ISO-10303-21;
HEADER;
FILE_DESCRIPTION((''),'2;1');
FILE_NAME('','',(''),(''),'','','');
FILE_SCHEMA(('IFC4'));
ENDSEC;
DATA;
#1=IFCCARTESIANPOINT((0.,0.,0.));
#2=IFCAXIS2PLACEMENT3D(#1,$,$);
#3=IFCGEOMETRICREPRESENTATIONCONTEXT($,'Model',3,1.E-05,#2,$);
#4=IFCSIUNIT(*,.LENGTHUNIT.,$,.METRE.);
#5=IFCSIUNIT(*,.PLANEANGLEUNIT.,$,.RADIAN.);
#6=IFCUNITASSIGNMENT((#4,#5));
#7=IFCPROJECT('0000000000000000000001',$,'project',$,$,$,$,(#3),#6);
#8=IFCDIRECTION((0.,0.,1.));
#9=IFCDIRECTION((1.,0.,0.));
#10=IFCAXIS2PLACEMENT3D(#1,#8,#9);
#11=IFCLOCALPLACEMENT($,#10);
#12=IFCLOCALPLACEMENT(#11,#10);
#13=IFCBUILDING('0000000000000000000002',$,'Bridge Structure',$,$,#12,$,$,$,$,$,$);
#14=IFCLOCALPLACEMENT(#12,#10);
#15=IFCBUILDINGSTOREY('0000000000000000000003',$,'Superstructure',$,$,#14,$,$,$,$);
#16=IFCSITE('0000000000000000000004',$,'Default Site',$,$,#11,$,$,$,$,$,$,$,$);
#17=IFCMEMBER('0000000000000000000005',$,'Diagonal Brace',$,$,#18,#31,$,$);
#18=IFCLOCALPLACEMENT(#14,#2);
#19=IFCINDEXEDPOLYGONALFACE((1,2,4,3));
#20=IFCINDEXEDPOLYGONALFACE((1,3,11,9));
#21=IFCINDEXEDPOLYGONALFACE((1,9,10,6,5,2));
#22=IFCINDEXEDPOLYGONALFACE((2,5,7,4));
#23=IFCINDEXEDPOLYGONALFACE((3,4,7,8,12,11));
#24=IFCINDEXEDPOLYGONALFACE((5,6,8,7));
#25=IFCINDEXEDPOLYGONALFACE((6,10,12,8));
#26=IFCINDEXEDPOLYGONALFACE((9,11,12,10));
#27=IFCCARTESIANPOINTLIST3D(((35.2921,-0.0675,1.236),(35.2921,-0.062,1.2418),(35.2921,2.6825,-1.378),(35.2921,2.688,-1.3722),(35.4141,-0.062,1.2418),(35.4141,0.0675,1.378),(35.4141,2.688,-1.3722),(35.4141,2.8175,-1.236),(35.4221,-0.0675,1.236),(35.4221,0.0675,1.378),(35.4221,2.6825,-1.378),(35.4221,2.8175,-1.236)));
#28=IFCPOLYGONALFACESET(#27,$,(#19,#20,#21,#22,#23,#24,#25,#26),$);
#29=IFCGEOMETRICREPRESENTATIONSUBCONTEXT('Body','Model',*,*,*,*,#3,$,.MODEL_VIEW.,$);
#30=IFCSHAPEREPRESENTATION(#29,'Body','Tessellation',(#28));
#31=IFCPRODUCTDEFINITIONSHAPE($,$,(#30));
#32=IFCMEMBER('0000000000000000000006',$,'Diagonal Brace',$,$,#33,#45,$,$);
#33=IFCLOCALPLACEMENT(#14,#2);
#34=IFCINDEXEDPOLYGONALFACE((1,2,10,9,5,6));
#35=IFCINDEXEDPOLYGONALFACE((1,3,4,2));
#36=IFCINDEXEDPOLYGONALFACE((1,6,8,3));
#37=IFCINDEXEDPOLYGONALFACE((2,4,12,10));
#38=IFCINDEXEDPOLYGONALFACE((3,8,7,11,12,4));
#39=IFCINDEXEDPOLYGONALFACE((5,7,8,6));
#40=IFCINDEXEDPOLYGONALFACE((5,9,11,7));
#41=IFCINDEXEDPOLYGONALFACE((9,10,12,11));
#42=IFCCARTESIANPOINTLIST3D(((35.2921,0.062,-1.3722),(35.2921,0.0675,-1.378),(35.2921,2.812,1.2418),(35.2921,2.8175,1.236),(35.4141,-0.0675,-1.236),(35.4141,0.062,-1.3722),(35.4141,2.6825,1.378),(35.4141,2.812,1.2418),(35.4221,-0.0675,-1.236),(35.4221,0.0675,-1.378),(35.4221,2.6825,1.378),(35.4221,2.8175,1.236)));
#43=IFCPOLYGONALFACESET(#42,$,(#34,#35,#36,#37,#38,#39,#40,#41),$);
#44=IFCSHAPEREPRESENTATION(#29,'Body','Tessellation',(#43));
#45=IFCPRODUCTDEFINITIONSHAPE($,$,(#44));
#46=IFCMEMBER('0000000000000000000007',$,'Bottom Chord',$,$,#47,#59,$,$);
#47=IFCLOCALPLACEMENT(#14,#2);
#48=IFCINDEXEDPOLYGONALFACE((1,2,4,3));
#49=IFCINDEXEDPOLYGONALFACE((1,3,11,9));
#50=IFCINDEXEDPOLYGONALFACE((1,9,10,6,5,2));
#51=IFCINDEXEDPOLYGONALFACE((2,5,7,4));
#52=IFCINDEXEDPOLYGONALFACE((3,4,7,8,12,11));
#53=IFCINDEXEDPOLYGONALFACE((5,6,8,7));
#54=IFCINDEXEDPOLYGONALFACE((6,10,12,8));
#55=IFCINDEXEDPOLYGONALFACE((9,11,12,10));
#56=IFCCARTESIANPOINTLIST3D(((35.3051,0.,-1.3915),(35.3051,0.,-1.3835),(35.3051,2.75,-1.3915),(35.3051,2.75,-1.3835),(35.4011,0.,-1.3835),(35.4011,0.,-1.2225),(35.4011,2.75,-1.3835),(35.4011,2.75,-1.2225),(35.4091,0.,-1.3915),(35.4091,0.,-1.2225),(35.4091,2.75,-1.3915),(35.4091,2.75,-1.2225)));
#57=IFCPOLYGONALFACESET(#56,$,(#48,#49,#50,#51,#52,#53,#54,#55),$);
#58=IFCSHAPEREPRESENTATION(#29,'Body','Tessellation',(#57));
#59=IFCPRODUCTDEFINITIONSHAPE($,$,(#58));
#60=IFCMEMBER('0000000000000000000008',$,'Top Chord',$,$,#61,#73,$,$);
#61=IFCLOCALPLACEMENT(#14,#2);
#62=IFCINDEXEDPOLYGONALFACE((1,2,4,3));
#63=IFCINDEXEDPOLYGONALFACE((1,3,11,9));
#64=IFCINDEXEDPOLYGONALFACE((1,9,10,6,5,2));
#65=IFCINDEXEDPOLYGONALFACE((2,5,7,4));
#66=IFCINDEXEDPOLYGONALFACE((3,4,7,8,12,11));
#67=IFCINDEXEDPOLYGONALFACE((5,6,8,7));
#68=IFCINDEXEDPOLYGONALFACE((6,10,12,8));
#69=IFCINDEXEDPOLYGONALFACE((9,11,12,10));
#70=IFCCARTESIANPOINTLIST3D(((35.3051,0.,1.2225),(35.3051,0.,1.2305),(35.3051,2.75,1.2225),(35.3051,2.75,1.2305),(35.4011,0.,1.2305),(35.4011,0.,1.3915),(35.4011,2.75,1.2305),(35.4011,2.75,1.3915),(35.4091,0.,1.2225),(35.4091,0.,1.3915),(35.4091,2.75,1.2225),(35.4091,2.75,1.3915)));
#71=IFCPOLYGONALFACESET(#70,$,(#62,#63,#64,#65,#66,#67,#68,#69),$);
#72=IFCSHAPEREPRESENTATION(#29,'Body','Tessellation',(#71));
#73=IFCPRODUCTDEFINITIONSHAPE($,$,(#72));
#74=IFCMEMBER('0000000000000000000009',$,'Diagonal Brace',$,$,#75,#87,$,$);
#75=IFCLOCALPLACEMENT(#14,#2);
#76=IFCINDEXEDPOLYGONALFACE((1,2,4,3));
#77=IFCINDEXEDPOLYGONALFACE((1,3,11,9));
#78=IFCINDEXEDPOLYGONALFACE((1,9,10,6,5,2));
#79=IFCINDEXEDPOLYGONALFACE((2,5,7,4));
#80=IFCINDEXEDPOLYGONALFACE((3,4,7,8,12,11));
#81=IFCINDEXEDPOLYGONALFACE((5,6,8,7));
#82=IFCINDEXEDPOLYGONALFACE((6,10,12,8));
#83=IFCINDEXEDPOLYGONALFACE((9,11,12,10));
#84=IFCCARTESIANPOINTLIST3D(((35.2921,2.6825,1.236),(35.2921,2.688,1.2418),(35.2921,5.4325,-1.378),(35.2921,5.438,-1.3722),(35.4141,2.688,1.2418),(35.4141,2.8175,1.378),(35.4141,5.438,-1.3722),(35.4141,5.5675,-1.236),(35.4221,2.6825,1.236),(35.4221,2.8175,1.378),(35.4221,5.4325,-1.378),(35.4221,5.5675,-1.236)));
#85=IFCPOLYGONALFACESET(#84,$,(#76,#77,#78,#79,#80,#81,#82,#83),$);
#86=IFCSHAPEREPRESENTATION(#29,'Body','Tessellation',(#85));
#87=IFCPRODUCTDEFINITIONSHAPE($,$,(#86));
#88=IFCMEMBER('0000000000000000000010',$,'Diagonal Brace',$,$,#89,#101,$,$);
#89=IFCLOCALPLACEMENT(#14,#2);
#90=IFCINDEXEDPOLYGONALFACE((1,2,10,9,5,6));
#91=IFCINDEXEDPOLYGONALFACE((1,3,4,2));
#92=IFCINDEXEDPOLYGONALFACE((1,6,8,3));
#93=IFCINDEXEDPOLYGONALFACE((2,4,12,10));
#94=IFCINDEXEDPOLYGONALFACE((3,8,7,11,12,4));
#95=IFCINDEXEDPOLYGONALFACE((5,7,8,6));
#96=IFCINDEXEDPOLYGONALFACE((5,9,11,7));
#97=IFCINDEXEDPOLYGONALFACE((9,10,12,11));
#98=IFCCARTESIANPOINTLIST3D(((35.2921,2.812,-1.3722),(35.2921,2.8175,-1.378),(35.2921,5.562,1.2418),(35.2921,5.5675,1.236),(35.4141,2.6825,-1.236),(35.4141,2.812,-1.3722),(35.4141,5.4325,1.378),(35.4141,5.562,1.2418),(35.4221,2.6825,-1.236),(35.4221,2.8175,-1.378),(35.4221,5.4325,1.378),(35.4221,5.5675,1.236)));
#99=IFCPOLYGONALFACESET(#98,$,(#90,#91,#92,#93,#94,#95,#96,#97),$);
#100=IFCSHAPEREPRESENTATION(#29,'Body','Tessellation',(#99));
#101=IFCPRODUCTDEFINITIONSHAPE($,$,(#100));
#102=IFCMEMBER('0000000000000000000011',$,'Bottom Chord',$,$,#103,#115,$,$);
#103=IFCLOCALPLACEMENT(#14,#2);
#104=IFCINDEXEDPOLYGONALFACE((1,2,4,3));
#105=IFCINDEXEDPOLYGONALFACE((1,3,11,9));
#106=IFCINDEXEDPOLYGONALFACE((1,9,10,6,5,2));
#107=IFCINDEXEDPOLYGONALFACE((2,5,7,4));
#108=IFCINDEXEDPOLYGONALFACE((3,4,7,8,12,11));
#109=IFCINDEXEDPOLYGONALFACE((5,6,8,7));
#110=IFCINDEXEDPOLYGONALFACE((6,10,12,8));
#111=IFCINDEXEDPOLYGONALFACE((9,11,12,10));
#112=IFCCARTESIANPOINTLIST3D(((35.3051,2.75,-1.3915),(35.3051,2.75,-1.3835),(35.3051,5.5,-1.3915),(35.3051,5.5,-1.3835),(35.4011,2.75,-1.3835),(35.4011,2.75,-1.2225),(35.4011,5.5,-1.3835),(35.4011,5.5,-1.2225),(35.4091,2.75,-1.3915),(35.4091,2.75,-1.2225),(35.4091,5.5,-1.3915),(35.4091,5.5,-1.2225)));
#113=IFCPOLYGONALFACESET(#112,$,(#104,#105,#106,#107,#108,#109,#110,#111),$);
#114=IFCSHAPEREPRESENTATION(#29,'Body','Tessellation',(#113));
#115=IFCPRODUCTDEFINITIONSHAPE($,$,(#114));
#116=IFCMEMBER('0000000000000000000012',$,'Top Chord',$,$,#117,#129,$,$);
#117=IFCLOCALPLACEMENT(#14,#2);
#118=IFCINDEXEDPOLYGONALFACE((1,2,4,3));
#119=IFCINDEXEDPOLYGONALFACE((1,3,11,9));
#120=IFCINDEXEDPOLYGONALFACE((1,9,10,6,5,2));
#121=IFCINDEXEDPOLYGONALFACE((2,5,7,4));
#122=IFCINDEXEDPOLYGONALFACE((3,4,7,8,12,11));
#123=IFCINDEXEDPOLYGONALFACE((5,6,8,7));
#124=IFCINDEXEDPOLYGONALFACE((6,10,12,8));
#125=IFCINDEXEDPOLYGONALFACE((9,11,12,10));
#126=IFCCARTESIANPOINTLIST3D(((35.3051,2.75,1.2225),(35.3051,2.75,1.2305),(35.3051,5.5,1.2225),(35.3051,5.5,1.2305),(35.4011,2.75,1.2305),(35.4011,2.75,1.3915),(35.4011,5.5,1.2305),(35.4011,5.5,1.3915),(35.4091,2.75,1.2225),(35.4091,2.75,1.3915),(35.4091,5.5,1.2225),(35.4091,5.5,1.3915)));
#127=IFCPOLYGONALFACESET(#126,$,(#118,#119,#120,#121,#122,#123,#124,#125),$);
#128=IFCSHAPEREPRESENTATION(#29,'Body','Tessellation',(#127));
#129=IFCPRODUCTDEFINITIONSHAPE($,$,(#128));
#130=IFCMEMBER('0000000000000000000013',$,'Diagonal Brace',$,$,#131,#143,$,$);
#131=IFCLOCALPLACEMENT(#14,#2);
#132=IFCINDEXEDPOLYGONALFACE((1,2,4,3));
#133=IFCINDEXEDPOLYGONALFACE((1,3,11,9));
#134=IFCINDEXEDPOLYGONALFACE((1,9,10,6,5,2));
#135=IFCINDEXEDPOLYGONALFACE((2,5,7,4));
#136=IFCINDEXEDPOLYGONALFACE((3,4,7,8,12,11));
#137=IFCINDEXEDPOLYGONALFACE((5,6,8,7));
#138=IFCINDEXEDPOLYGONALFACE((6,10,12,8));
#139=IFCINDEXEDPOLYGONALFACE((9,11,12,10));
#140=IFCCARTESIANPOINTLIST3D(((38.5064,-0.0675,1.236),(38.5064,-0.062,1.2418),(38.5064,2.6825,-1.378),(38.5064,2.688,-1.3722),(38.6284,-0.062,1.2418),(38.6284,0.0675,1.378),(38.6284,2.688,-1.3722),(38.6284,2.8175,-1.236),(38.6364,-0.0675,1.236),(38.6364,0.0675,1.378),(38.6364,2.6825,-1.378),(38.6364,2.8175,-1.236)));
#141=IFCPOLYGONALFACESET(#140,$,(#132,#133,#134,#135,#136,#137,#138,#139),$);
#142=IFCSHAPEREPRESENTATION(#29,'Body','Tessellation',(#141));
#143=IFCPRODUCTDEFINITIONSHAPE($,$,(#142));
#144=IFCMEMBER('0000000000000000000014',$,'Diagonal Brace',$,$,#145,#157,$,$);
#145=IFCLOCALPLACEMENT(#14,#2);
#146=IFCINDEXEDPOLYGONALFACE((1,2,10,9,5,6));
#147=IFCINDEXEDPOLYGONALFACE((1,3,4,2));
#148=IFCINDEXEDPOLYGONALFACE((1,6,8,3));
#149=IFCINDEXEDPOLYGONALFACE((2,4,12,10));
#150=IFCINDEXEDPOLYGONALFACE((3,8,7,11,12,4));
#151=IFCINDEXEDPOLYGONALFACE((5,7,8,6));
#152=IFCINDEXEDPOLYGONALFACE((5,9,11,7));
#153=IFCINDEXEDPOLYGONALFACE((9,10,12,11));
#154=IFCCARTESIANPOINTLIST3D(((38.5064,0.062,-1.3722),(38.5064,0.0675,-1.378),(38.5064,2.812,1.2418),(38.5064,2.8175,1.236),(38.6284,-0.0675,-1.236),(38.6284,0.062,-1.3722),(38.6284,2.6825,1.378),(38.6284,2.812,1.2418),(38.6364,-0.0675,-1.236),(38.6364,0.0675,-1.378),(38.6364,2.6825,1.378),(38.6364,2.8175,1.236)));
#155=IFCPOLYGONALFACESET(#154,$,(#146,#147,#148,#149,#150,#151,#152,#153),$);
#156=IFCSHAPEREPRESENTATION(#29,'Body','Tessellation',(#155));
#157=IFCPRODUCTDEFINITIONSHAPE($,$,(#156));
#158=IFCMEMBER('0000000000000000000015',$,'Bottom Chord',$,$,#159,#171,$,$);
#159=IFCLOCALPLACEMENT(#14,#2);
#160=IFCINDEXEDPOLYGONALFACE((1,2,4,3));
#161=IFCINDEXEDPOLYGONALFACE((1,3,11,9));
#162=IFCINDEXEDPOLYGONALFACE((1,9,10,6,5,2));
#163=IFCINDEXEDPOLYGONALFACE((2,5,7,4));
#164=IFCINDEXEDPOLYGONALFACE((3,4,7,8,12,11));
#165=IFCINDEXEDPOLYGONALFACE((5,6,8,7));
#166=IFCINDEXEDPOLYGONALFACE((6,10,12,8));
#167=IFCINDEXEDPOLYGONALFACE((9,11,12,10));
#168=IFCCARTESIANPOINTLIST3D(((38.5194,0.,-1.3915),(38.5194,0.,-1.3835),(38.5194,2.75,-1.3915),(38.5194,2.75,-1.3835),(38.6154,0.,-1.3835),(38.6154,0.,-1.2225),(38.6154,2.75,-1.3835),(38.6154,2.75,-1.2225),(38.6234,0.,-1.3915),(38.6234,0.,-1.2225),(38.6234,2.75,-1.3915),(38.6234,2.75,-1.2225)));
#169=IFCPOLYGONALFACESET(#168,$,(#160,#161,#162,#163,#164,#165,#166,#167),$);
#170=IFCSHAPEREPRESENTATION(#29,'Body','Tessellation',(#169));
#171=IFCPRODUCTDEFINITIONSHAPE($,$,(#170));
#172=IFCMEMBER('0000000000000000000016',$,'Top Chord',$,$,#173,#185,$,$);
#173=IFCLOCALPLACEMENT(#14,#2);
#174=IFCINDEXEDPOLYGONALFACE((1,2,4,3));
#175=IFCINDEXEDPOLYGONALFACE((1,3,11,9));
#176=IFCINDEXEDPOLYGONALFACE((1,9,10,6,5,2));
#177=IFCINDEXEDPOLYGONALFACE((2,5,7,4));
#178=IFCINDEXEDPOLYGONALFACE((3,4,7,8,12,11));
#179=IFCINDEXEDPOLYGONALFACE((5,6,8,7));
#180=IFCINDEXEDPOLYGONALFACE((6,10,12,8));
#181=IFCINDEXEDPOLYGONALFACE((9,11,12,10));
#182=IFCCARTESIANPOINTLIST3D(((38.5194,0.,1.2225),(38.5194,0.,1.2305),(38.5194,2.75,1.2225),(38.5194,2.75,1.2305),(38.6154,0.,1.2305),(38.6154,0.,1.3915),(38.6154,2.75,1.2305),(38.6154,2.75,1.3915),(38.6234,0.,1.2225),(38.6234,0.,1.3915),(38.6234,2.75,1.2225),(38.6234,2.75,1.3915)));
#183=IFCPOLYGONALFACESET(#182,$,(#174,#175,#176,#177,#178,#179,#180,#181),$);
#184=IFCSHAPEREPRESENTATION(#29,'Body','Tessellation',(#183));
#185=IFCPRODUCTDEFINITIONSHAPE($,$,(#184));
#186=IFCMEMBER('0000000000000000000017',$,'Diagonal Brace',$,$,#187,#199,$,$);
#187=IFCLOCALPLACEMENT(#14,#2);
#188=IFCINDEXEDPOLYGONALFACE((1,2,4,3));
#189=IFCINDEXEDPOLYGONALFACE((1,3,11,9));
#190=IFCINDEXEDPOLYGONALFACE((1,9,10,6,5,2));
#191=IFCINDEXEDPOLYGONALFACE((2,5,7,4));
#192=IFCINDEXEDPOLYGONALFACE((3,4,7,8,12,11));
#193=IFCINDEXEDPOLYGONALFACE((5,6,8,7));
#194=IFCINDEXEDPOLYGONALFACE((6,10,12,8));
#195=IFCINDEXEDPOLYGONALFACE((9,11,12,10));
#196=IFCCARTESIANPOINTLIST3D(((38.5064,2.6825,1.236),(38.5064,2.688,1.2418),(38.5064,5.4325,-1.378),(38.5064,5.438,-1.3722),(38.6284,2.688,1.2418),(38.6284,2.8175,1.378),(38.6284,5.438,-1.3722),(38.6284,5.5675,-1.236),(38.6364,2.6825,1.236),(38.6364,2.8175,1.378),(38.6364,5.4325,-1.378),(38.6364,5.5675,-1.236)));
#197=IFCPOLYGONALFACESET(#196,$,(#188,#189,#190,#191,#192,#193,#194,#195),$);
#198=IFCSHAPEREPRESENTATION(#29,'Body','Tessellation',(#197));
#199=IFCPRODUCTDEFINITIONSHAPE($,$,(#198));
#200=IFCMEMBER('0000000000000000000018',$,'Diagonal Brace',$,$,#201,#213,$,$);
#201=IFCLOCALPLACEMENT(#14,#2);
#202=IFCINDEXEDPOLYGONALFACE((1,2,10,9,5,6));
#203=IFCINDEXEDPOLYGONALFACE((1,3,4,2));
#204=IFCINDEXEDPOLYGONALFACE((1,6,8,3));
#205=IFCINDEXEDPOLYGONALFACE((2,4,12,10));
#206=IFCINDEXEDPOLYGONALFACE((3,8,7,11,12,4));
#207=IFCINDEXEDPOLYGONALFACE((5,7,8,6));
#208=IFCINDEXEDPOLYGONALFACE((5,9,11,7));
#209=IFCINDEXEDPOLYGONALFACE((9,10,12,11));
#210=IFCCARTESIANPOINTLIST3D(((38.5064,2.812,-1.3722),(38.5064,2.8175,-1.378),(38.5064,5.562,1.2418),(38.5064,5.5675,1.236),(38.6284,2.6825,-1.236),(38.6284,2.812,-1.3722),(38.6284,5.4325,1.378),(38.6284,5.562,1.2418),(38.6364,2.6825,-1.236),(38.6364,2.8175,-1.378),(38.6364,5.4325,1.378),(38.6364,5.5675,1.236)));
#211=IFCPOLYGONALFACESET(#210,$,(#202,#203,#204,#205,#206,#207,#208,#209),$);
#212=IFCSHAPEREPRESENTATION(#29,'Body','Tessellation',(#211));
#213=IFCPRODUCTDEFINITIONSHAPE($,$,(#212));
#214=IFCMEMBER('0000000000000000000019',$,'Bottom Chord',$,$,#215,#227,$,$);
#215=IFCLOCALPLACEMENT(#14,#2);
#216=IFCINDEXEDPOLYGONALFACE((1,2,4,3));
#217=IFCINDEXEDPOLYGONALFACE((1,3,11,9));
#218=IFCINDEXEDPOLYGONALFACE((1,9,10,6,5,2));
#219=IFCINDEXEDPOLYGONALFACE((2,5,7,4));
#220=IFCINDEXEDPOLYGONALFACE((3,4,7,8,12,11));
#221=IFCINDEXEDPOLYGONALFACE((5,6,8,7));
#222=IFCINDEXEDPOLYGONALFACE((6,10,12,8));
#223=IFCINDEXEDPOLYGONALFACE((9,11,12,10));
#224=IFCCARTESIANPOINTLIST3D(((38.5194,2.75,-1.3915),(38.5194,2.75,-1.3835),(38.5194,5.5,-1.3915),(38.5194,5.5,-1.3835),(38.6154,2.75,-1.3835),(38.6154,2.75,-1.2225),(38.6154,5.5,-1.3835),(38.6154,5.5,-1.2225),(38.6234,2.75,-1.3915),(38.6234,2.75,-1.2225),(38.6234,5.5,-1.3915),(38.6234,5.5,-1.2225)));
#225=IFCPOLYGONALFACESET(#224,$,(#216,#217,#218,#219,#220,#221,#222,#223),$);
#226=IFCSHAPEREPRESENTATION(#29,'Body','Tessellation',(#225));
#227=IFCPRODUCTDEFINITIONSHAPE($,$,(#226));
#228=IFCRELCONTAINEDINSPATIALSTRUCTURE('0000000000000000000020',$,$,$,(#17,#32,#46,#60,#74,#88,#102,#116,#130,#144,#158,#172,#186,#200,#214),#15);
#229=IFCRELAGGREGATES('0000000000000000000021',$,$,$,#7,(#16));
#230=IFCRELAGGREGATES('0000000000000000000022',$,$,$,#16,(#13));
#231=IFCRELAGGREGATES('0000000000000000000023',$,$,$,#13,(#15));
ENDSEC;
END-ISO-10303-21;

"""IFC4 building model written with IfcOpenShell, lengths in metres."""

from ifc_helpers import new_model, si_unit, frame, origin, origin_with_axes, origin_2d_with_axis, place, context, subcontext, project, spatial, l_section, extrude, element, save


model = new_model("IFC4")

# Units and contexts
model_context = context("Model", 3, precision=1e-05, world=origin())
body_context = subcontext(model_context, "Body", "Model", "MODEL_VIEW")
ifc_project = project(units=[si_unit("LENGTHUNIT", "METRE"), si_unit("PLANEANGLEUNIT", "RADIAN")], contexts=[model_context])

# Site, building, storey
site_placement = place(None, origin_with_axes())
site = spatial("IfcSite", under=ifc_project, at=site_placement, Name="Default Site")
building_placement = place(site_placement, origin_with_axes())
building = spatial("IfcBuilding", under=site, at=building_placement, Name="Bridge Structure")
storey_placement = place(building_placement, origin_with_axes())
storey = spatial("IfcBuildingStorey", under=building, at=storey_placement, Name="Superstructure")

# Members
for number, where, z_axis, x_axis, name in (
    (1, (35.3571, 0.0, 1.307), (0.0, 0.724802, -0.688957), (-1.0, 0.0, 0.0), "Diagonal Brace"),
    (2, (35.3571, 0.0, -1.307), (0.0, 0.724802, 0.688957), (-1.0, 0.0, 0.0), "Diagonal Brace"),
):
    element("IfcMember", number, at=place(storey_placement, frame(where, z_axis=z_axis, x_axis=x_axis)), inside=storey, Name=name, context=body_context, shape_type="SweptSolid", body=[
        extrude(l_section(Depth=0.196, Width=0.13, Thickness=0.008, at=origin_2d_with_axis()), origin_with_axes(), (0.0, 0.0, 1.0), 3.7941),
    ])
for number, where, z_axis, x_axis, name in (
    (3, (35.3571, 0.0, -1.307), (0.0, 1.0, 0.0), (-1.0, 0.0, 0.0), "Bottom Chord"),
    (4, (35.3571, 0.0, 1.307), (0.0, 1.0, 0.0), (-1.0, 0.0, 0.0), "Top Chord"),
):
    element("IfcMember", number, at=place(storey_placement, frame(where, z_axis=z_axis, x_axis=x_axis)), inside=storey, Name=name, context=body_context, shape_type="SweptSolid", body=[
        extrude(l_section(Depth=0.169, Width=0.104, Thickness=0.008, at=origin_2d_with_axis()), origin_with_axes(), (0.0, 0.0, 1.0), 2.75),
    ])
for number, where, z_axis, x_axis, name in (
    (5, (35.3571, 2.75, 1.307), (0.0, 0.724802, -0.688957), (-1.0, 0.0, 0.0), "Diagonal Brace"),
    (6, (35.3571, 2.75, -1.307), (0.0, 0.724802, 0.688957), (-1.0, 0.0, 0.0), "Diagonal Brace"),
):
    element("IfcMember", number, at=place(storey_placement, frame(where, z_axis=z_axis, x_axis=x_axis)), inside=storey, Name=name, context=body_context, shape_type="SweptSolid", body=[
        extrude(l_section(Depth=0.196, Width=0.13, Thickness=0.008, at=origin_2d_with_axis()), origin_with_axes(), (0.0, 0.0, 1.0), 3.7941),
    ])
for number, where, z_axis, x_axis, name in (
    (7, (35.3571, 2.75, -1.307), (0.0, 1.0, 0.0), (-1.0, 0.0, 0.0), "Bottom Chord"),
    (8, (35.3571, 2.75, 1.307), (0.0, 1.0, 0.0), (-1.0, 0.0, 0.0), "Top Chord"),
):
    element("IfcMember", number, at=place(storey_placement, frame(where, z_axis=z_axis, x_axis=x_axis)), inside=storey, Name=name, context=body_context, shape_type="SweptSolid", body=[
        extrude(l_section(Depth=0.169, Width=0.104, Thickness=0.008, at=origin_2d_with_axis()), origin_with_axes(), (0.0, 0.0, 1.0), 2.75),
    ])
for number, where, z_axis, x_axis, name in (
    (9, (38.5714, 0.0, 1.307), (0.0, 0.724802, -0.688957), (-1.0, 0.0, 0.0), "Diagonal Brace"),
    (10, (38.5714, 0.0, -1.307), (0.0, 0.724802, 0.688957), (-1.0, 0.0, 0.0), "Diagonal Brace"),
):
    element("IfcMember", number, at=place(storey_placement, frame(where, z_axis=z_axis, x_axis=x_axis)), inside=storey, Name=name, context=body_context, shape_type="SweptSolid", body=[
        extrude(l_section(Depth=0.196, Width=0.13, Thickness=0.008, at=origin_2d_with_axis()), origin_with_axes(), (0.0, 0.0, 1.0), 3.7941),
    ])
for number, where, z_axis, x_axis, name in (
    (11, (38.5714, 0.0, -1.307), (0.0, 1.0, 0.0), (-1.0, 0.0, 0.0), "Bottom Chord"),
    (12, (38.5714, 0.0, 1.307), (0.0, 1.0, 0.0), (-1.0, 0.0, 0.0), "Top Chord"),
):
    element("IfcMember", number, at=place(storey_placement, frame(where, z_axis=z_axis, x_axis=x_axis)), inside=storey, Name=name, context=body_context, shape_type="SweptSolid", body=[
        extrude(l_section(Depth=0.169, Width=0.104, Thickness=0.008, at=origin_2d_with_axis()), origin_with_axes(), (0.0, 0.0, 1.0), 2.75),
    ])
for number, where, z_axis, x_axis, name in (
    (13, (38.5714, 2.75, 1.307), (0.0, 0.724802, -0.688957), (-1.0, 0.0, 0.0), "Diagonal Brace"),
    (14, (38.5714, 2.75, -1.307), (0.0, 0.724802, 0.688957), (-1.0, 0.0, 0.0), "Diagonal Brace"),
):
    element("IfcMember", number, at=place(storey_placement, frame(where, z_axis=z_axis, x_axis=x_axis)), inside=storey, Name=name, context=body_context, shape_type="SweptSolid", body=[
        extrude(l_section(Depth=0.196, Width=0.13, Thickness=0.008, at=origin_2d_with_axis()), origin_with_axes(), (0.0, 0.0, 1.0), 3.7941),
    ])
member_placement = place(storey_placement, frame((38.5714, 2.75, -1.307), z_axis=(0.0, 1.0, 0.0), x_axis=(-1.0, 0.0, 0.0)))
element("IfcMember", 15, at=member_placement, inside=storey, Name="Bottom Chord", context=body_context, shape_type="SweptSolid", body=[
    extrude(l_section(Depth=0.169, Width=0.104, Thickness=0.008, at=origin_2d_with_axis()), origin_with_axes(), (0.0, 0.0, 1.0), 2.75),
])

save(model, "model.ifc")
